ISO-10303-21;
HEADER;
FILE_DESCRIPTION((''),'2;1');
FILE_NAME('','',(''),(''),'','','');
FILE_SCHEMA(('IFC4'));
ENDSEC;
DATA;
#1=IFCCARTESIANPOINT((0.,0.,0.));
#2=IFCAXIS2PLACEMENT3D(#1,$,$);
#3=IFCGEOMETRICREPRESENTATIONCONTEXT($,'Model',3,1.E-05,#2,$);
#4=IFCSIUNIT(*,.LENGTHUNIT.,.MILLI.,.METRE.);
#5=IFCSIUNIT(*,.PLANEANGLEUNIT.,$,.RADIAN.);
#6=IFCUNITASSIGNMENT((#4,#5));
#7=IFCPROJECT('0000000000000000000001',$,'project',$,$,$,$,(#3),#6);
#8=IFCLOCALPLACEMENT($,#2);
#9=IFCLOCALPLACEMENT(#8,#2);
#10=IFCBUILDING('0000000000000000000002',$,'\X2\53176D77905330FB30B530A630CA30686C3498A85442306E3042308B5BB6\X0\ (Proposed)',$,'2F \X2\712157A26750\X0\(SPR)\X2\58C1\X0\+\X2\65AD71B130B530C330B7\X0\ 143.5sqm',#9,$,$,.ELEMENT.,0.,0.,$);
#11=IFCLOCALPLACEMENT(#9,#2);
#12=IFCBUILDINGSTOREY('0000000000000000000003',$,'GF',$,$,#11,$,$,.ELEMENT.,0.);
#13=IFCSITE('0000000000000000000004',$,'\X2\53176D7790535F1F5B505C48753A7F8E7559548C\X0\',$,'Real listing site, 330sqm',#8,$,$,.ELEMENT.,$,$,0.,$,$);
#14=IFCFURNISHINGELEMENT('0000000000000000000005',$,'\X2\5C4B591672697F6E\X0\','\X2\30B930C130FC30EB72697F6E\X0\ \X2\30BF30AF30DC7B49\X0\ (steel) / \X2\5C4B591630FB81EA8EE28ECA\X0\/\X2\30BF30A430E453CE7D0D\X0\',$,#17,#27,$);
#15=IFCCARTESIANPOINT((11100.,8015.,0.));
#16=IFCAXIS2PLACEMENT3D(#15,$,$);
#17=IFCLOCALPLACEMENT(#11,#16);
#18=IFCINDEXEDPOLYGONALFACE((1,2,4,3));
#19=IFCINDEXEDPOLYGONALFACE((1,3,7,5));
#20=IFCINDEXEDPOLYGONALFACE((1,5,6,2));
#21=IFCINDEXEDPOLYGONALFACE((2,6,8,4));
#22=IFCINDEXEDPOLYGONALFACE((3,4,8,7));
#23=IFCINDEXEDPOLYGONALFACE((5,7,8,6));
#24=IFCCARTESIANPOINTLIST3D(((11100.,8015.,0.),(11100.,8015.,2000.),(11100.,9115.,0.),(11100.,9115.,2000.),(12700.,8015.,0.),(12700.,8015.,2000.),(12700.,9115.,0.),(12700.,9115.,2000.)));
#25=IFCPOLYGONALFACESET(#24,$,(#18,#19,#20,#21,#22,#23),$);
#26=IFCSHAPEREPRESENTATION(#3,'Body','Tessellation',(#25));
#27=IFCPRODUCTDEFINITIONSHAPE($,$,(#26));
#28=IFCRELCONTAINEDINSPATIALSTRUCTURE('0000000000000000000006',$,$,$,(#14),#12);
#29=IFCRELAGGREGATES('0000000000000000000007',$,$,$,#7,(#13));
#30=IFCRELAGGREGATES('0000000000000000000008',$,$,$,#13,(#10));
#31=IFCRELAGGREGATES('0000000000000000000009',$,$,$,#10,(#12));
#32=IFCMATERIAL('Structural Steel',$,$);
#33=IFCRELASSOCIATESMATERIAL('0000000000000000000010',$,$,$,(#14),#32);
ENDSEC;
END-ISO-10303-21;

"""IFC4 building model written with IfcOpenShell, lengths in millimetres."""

from ifc_helpers import new_model, si_unit, frame, frame_2d, origin, place, context, project, spatial, rectangle, extrude, material, element, save


model = new_model("IFC4")

# Units and contexts
model_context = context("Model", 3, precision=1e-05, world=origin())
ifc_project = project(units=[si_unit("LENGTHUNIT", "METRE", prefix="MILLI"), si_unit("PLANEANGLEUNIT", "RADIAN")], contexts=[model_context])

# Site, building, storey
site_placement = place(None, origin())
site = spatial("IfcSite", under=ifc_project, at=site_placement, Name="北海道弟子屈町美留和", ObjectType="Real listing site, 330sqm", CompositionType="ELEMENT", RefElevation=0.0)
building_placement = place(site_placement, origin())
building = spatial("IfcBuilding", under=site, at=building_placement, Name="北海道・サウナと水風呂のある家 (Proposed)", ObjectType="2F 無垢材(SPR)壁+断熱サッシ 143.5sqm", CompositionType="ELEMENT", ElevationOfRefHeight=0.0, ElevationOfTerrain=0.0)
storey_placement = place(building_placement, origin())
storey = spatial("IfcBuildingStorey", under=building, at=storey_placement, Name="GF", CompositionType="ELEMENT", Elevation=0.0)

# Shared definitions
ifc_material_1 = material(Name="Structural Steel")

# Furnishing element
furnishing_placement = place(storey_placement, frame((11100.0, 8015.0, 0.0)))
element("IfcFurnishingElement", 1, at=furnishing_placement, inside=storey, material=ifc_material_1, Name="屋外物置", Description="スチール物置 タクボ等 (steel) / 屋外・自転車/タイヤ収納", context=model_context, shape_type="SweptSolid", body=[
    extrude(rectangle(XDim=1600.0, YDim=1100.0, at=frame_2d((800.0, 550.0))), frame((11100.0, 8015.0, 0.0)), (0.0, 0.0, 1.0), 2000.0),
])

save(model, "model.ifc")
